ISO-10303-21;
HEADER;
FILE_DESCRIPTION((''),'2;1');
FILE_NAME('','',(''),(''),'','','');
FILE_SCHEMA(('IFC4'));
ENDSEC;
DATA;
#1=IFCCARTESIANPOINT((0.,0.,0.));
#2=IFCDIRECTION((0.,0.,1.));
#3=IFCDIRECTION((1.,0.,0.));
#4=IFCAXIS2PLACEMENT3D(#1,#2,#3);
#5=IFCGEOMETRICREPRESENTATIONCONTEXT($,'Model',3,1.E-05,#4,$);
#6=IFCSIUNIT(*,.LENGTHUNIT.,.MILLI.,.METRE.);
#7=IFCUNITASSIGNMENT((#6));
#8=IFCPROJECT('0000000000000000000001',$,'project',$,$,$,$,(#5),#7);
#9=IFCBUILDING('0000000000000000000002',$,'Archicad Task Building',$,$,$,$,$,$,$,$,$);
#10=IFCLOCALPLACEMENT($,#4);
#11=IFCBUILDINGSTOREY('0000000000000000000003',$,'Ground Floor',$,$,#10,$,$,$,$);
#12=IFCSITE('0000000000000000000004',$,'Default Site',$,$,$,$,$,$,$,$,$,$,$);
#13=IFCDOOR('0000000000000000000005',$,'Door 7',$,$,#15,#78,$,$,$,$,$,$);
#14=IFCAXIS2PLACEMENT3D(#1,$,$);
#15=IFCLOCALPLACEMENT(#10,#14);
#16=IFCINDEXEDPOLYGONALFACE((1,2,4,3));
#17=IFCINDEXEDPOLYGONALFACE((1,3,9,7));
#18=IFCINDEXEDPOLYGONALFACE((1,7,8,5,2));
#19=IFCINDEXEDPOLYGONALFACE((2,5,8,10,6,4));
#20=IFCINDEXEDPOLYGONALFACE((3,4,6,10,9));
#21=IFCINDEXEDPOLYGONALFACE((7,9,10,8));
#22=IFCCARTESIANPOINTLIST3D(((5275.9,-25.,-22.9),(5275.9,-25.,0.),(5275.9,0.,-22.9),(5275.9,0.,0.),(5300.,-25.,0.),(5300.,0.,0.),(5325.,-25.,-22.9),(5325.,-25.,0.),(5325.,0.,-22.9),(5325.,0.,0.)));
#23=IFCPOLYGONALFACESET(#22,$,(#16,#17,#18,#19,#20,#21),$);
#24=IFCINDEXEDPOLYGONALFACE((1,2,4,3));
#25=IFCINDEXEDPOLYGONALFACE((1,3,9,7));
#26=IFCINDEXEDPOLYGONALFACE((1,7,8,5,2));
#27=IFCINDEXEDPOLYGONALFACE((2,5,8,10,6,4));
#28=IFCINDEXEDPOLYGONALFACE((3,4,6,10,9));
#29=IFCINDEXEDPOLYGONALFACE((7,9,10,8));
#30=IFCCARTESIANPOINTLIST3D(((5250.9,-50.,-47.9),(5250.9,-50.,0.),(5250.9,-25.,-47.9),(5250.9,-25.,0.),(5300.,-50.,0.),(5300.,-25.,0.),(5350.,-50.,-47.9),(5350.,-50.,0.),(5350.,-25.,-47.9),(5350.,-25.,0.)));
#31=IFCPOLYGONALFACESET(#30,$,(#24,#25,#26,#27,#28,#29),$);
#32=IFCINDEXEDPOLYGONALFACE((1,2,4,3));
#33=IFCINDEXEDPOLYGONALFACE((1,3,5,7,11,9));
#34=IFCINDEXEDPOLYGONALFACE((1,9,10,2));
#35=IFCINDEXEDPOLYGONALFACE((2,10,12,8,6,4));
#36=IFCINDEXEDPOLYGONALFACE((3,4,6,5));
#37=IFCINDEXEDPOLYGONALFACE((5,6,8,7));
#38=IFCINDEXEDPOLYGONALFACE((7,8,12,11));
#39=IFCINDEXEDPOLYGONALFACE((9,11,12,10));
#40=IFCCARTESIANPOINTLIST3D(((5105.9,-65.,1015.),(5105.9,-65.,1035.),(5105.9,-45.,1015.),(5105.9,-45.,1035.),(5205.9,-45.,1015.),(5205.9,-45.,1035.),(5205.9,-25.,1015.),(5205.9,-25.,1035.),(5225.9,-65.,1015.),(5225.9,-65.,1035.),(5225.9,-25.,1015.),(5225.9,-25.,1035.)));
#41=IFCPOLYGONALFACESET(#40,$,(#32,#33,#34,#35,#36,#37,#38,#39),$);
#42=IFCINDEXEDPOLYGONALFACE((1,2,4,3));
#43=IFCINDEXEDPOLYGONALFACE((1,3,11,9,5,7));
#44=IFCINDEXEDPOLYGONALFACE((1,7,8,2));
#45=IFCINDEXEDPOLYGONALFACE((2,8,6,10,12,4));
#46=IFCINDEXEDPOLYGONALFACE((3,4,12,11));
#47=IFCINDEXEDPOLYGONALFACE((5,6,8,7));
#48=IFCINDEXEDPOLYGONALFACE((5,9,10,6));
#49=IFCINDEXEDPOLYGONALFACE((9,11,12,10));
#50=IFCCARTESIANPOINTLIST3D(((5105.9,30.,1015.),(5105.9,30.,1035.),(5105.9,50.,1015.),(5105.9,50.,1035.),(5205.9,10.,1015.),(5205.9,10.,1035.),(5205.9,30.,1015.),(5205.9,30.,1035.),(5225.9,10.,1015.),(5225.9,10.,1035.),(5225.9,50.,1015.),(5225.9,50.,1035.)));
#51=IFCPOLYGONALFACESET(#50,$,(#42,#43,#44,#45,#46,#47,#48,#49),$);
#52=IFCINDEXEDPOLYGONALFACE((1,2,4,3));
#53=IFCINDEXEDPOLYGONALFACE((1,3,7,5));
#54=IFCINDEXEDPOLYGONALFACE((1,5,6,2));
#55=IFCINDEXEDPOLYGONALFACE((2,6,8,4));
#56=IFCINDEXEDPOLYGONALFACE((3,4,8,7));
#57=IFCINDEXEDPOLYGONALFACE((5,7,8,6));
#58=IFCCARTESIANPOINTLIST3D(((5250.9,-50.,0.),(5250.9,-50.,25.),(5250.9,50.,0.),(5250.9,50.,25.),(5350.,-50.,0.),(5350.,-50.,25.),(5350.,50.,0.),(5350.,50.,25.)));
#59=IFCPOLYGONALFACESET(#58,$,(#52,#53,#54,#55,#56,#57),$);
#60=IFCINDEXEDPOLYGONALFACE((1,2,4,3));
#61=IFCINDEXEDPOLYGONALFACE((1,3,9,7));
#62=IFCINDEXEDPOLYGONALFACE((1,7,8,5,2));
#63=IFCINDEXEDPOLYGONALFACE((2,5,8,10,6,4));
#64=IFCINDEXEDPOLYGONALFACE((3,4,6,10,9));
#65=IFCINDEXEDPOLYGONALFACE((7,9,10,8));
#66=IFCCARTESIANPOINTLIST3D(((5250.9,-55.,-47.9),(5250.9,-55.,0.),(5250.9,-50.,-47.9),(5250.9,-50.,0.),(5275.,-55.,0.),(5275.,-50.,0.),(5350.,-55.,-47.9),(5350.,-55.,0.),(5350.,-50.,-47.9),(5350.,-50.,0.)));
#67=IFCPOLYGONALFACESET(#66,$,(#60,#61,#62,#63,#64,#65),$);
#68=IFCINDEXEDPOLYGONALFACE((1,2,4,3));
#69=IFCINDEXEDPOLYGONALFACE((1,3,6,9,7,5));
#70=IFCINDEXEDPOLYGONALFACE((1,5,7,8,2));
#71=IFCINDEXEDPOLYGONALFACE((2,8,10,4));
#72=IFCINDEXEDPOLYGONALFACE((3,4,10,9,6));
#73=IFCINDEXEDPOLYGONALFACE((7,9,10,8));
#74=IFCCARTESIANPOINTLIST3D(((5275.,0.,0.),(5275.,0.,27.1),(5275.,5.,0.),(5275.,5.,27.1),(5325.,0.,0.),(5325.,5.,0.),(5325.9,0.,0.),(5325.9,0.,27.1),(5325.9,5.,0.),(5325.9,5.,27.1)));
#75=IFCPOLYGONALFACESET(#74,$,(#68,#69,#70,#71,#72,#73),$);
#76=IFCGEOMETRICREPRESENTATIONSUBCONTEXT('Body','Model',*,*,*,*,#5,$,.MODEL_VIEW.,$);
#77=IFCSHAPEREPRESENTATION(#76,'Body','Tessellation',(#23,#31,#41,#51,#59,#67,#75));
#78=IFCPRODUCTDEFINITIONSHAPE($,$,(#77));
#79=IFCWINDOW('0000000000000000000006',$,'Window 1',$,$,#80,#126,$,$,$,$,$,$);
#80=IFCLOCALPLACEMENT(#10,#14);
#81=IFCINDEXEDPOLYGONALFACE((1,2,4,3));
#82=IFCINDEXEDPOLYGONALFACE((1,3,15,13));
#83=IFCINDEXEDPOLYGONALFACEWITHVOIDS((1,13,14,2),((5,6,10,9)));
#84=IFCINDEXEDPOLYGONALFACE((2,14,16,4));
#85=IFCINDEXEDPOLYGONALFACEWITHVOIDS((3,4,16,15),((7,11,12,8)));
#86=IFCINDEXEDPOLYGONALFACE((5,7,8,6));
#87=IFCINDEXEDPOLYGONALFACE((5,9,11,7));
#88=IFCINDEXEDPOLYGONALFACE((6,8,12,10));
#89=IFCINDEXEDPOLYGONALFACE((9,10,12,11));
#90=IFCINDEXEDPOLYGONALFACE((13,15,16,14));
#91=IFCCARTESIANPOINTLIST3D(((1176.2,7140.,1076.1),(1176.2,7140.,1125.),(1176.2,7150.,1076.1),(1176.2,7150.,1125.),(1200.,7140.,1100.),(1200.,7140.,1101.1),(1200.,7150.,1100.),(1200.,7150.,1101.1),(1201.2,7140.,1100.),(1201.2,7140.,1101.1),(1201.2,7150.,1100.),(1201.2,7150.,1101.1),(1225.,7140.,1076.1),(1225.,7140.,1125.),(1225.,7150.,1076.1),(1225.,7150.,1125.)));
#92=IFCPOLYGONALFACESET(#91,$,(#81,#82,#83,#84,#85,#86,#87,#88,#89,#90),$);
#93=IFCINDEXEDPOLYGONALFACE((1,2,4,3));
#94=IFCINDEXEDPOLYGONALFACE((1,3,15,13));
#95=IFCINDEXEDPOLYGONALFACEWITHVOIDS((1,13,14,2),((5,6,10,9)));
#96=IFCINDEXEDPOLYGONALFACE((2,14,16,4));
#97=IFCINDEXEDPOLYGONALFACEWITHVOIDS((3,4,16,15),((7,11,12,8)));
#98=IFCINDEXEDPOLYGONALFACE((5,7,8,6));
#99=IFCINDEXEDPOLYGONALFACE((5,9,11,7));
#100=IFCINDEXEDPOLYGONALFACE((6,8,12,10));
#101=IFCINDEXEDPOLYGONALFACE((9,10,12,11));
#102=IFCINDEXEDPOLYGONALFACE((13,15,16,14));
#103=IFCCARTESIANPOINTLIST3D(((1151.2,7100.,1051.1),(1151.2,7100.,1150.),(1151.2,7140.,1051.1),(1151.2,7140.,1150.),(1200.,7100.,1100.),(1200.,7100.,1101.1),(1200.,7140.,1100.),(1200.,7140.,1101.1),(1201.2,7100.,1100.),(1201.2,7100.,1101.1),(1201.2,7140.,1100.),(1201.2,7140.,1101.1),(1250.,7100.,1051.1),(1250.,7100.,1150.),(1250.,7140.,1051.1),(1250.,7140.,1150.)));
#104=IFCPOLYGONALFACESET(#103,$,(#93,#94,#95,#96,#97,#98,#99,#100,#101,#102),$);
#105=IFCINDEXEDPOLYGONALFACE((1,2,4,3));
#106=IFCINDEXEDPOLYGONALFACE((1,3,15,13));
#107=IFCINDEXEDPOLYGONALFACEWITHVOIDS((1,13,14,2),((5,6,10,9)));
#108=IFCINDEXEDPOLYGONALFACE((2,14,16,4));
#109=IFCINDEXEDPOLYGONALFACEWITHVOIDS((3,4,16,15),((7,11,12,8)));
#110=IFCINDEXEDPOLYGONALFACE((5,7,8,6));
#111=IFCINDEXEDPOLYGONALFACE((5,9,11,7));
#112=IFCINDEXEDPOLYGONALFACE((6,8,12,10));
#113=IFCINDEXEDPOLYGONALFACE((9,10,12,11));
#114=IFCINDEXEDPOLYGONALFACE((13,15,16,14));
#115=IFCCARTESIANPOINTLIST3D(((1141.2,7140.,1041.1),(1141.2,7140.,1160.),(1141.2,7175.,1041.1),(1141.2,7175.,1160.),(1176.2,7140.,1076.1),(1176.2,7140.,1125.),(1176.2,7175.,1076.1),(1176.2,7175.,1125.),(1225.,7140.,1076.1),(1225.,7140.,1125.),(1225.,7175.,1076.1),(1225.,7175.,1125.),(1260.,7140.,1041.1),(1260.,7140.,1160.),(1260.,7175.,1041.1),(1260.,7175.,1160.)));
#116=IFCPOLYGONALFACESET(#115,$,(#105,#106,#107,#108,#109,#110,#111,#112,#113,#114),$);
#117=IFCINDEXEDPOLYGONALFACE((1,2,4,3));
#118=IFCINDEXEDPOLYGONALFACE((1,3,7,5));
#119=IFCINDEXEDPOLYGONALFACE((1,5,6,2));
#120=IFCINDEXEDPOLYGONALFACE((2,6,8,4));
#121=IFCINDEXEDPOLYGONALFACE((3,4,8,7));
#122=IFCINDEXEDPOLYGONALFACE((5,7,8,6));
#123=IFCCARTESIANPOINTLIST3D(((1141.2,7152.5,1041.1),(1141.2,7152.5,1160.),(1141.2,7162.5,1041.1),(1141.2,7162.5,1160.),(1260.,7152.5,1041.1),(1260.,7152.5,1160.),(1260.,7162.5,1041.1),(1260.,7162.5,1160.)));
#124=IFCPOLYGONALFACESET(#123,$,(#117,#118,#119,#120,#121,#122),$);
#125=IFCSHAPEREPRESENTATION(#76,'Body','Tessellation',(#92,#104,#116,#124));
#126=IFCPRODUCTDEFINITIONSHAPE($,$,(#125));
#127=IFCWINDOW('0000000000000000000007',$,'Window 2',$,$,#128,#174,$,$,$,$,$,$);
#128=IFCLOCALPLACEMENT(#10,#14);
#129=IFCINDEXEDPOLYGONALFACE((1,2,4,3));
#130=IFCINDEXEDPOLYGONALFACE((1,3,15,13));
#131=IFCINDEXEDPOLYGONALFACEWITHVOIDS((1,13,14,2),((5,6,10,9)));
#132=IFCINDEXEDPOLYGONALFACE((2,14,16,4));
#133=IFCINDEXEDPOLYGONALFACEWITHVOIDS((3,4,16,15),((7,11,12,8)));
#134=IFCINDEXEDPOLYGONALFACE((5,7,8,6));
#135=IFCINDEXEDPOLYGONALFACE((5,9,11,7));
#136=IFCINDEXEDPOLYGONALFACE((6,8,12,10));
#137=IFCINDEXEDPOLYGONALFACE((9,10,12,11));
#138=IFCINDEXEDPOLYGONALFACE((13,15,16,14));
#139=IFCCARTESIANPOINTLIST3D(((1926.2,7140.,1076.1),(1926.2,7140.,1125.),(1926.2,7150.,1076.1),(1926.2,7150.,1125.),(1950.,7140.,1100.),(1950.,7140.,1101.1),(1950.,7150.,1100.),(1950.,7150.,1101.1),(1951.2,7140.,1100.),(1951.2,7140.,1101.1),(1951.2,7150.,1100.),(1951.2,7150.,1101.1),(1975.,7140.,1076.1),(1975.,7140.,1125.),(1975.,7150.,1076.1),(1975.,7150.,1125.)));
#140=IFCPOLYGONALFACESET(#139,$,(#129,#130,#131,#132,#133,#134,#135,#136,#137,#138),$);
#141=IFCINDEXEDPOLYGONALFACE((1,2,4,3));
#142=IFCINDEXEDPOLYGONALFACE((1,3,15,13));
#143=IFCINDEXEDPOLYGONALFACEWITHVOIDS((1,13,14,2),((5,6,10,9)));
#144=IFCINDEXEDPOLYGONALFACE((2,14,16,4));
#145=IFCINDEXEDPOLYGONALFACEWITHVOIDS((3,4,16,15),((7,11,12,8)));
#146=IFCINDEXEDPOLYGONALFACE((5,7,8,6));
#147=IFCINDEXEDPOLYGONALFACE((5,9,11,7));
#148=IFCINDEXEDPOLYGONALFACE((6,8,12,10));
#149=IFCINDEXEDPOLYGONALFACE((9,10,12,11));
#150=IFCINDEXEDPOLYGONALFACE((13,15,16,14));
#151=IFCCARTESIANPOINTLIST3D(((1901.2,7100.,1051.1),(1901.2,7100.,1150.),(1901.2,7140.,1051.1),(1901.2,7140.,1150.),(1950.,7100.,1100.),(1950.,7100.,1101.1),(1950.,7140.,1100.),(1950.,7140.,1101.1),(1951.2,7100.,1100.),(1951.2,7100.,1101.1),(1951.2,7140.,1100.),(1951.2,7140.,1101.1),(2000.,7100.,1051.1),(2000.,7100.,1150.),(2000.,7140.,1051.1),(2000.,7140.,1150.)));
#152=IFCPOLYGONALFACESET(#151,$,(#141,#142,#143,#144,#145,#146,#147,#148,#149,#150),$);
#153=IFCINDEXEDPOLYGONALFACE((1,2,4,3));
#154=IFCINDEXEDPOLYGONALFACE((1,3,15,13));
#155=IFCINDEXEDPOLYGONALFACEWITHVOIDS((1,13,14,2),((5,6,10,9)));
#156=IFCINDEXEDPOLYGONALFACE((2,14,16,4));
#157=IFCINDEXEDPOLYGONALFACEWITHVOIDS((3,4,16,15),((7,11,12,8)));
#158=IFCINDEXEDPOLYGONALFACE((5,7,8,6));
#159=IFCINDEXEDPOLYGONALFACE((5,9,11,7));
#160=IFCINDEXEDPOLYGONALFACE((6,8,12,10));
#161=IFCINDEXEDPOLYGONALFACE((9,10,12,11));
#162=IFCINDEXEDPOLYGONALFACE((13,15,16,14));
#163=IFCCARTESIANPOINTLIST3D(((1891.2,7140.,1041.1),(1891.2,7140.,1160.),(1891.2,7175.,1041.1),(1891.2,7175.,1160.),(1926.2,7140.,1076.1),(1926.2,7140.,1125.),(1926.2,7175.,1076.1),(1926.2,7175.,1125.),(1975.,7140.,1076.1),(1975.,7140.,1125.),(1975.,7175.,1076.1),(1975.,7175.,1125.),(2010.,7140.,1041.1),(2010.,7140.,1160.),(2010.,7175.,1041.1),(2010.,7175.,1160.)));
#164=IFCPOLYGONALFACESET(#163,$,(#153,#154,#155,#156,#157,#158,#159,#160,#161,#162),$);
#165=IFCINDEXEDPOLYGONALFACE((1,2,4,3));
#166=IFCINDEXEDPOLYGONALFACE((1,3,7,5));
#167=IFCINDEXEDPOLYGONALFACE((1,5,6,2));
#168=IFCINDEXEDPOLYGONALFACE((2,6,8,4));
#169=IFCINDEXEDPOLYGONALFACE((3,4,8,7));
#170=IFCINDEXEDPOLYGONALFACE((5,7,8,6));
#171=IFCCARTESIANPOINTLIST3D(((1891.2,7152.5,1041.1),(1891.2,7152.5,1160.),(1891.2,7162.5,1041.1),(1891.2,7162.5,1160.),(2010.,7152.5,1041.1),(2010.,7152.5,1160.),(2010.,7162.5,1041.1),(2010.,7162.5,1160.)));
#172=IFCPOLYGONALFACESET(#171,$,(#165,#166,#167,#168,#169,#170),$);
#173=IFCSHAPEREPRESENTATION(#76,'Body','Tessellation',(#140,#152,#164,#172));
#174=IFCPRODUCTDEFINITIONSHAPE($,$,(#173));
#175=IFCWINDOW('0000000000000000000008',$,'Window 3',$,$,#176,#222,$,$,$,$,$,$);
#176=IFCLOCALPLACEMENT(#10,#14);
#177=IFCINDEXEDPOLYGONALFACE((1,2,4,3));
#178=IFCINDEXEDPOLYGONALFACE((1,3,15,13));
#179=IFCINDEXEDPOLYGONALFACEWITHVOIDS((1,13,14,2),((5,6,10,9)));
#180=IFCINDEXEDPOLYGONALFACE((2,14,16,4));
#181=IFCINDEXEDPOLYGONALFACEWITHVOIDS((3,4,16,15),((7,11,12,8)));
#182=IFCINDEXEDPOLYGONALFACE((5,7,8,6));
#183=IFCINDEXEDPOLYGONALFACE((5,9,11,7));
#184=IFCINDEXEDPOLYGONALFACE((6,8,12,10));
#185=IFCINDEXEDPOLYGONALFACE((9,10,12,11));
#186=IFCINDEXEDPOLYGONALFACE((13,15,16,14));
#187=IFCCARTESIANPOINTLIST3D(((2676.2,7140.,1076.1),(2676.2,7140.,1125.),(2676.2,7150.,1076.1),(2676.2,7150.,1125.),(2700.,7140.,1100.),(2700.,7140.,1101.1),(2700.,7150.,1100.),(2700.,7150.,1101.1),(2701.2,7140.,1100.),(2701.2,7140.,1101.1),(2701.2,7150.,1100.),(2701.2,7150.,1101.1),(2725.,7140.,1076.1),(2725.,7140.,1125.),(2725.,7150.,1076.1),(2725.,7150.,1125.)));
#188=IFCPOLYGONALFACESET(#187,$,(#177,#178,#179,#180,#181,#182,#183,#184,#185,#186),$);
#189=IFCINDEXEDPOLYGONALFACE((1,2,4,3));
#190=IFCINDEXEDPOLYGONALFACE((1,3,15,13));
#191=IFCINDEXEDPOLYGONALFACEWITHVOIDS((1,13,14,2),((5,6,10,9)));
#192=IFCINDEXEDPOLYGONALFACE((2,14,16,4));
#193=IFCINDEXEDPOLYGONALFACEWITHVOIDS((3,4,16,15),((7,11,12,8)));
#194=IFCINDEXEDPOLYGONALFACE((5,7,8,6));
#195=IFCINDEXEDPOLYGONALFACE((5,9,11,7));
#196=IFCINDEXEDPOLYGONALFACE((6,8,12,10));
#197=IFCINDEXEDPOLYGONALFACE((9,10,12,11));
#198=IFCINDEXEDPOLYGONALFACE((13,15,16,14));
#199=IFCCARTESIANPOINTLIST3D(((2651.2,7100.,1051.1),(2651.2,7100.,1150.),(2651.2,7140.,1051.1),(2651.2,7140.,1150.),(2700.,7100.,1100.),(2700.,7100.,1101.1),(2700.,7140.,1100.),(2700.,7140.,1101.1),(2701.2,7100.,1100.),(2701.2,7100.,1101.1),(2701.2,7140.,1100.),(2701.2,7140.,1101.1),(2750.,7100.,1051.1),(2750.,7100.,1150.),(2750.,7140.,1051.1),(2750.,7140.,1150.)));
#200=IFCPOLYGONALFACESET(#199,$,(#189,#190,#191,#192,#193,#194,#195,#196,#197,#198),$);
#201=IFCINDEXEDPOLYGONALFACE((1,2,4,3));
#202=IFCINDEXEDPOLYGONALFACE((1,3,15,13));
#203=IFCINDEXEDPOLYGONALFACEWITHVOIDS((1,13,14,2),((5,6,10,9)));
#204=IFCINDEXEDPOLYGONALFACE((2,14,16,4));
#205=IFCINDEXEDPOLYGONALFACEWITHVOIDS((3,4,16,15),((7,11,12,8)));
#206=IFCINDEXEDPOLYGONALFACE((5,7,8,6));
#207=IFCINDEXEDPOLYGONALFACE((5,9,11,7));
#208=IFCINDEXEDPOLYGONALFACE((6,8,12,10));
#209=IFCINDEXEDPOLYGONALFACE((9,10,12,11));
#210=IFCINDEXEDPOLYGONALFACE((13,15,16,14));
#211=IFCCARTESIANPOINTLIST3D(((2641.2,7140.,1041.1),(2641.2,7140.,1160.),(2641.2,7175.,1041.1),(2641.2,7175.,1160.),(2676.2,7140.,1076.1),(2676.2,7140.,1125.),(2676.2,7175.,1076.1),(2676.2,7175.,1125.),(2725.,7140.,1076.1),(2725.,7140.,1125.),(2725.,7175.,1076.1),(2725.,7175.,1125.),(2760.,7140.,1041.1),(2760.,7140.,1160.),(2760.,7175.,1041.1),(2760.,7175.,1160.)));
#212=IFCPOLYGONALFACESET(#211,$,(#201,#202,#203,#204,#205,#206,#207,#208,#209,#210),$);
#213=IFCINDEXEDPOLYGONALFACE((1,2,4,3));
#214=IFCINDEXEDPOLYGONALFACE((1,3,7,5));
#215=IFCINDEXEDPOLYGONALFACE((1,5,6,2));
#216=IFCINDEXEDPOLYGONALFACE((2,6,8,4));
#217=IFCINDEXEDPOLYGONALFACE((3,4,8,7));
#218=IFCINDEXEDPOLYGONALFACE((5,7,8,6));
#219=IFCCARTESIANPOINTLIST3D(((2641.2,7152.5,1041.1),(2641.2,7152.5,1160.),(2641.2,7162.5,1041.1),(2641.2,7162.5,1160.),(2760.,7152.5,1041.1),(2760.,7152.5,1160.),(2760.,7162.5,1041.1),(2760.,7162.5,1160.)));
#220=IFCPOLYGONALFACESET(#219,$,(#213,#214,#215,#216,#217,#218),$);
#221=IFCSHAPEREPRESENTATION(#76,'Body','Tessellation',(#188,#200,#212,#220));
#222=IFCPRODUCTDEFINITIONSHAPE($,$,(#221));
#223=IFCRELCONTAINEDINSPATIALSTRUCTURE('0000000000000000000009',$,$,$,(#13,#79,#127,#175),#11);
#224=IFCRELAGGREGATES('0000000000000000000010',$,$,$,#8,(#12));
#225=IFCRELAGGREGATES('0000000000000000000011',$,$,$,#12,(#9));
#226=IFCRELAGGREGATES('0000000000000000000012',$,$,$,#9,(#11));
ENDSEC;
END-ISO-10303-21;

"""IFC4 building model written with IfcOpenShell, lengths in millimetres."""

from ifc_helpers import new_model, si_unit, frame, origin_with_axes, place, context, subcontext, project, spatial, line, indexed_curve, outline, extrude, element, save


model = new_model("IFC4")

# Units and contexts
model_context = context("Model", 3, precision=1e-05, world=origin_with_axes())
body_context = subcontext(model_context, "Body", "Model", "MODEL_VIEW")
ifc_project = project(units=[si_unit("LENGTHUNIT", "METRE", prefix="MILLI")], contexts=[model_context])

# Site, building, storey
site = spatial("IfcSite", under=ifc_project, Name="Default Site")
building = spatial("IfcBuilding", under=site, Name="Archicad Task Building")
storey_placement = place(None, origin_with_axes())
storey = spatial("IfcBuildingStorey", under=building, at=storey_placement, Name="Ground Floor")

# Door
door_1_placement = place(storey_placement, frame((5300.0, -50.0, 0.0), z_axis=(0.0, 0.0, 1.0), x_axis=(1.0, 0.0, 0.0)))
element("IfcDoor", 1, at=door_1_placement, inside=storey, Name="Door 7", context=body_context, shape_type="SweptSolid", body=[
    extrude(outline(indexed_curve([(0.0, 0.0), (0.0, 2.1), (0.9, 2.1), (0.9, 0.0), (-24.1, 0.0), (-24.1, -22.9), (25.0, -22.9), (25.0, 0.0)], segments=[line(1, 2, 3, 4, 5, 6, 7, 8, 1)])), frame((0.0, 25.0, 0.0), z_axis=(0.0, -1.0, 0.0), x_axis=(1.0, 0.0, 0.0)), (0.0, 0.0, -1.0), 25.0),
    extrude(outline(indexed_curve([(0.0, 0.0), (0.0, 2.1), (0.9, 2.1), (0.9, 0.0), (-49.1, 0.0), (-49.1, -47.9), (50.0, -47.9), (50.0, 0.0)], segments=[line(1, 2, 3, 4, 5, 6, 7, 8, 1)])), frame((0.0, 0.0, 0.0), z_axis=(0.0, -1.0, 0.0), x_axis=(1.0, 0.0, 0.0)), (0.0, 0.0, -1.0), 25.0),
    extrude(outline(indexed_curve([(0.0, 0.0), (-49.1, 0.0), (-49.1, 35.0), (0.0, 35.0)], segments=[line(1, 2, 3, 4, 1)])), frame((25.0, 25.0, 25.0), z_axis=(0.0, 0.0, 1.0), x_axis=(1.0, 0.0, 0.0)), (0.0, 0.0, 1.0), -47.9),
    extrude(outline(indexed_curve([(0.0, 0.0), (0.0, -40.0), (-120.0, -40.0), (-120.0, -20.0), (-20.0, -20.0), (-20.0, 0.0)], segments=[line(1, 2, 3, 4, 5, 6, 1)])), frame((-74.1, 25.0, 1015.0), z_axis=(0.0, 0.0, 1.0), x_axis=(1.0, 0.0, 0.0)), (0.0, 0.0, 1.0), 20.0),
    extrude(outline(indexed_curve([(0.0, 0.0), (0.0, 40.0), (-120.0, 40.0), (-120.0, 20.0), (-20.0, 20.0), (-20.0, 0.0)], segments=[line(1, 2, 3, 4, 5, 6, 1)])), frame((-74.1, 60.0, 1015.0), z_axis=(0.0, 0.0, 1.0), x_axis=(1.0, 0.0, 0.0)), (0.0, 0.0, 1.0), 20.0),
    extrude(outline(indexed_curve([(0.0, 0.0), (-99.1, 0.0), (-99.1, 100.0), (0.0, 100.0)], segments=[line(1, 2, 3, 4, 1)])), frame((50.0, 0.0, 0.0), z_axis=(0.0, 0.0, 1.0), x_axis=(1.0, 0.0, 0.0)), (0.0, 0.0, 1.0), 25.0),
    extrude(outline(indexed_curve([(0.0, 0.0), (0.0, 27.1), (50.9, 27.1), (50.9, 0.0), (-24.1, 0.0), (-24.1, -47.9), (75.0, -47.9), (75.0, 0.0)], segments=[line(1, 2, 3, 4, 5, 6, 7, 8, 1)])), frame((-25.0, -5.0, 0.0), z_axis=(0.0, -1.0, 0.0), x_axis=(1.0, 0.0, 0.0)), (0.0, 0.0, -1.0), 5.0),
    extrude(outline(indexed_curve([(0.0, 0.0), (0.0, 27.1), (50.9, 27.1), (50.9, 0.0), (0.9, 0.0), (0.9, -22.9), (50.0, -22.9), (50.0, 0.0)], segments=[line(1, 2, 3, 4, 5, 6, 7, 8, 1)])), frame((-25.0, 50.0, 0.0), z_axis=(0.0, -1.0, 0.0), x_axis=(1.0, 0.0, 0.0)), (0.0, 0.0, -1.0), 5.0),
])

# Windows
for number, where, z_axis, x_axis, name in (
    (2, (1200.0, 7050.0, 1100.0), (0.0, 0.0, 1.0), (1.0, 0.0, 0.0), "Window 1"),
    (3, (1950.0, 7050.0, 1100.0), (0.0, 0.0, 1.0), (1.0, 0.0, 0.0), "Window 2"),
    (4, (2700.0, 7050.0, 1100.0), (0.0, 0.0, 1.0), (1.0, 0.0, 0.0), "Window 3"),
):
    element("IfcWindow", number, at=place(storey_placement, frame(where, z_axis=z_axis, x_axis=x_axis)), inside=storey, Name=name, context=body_context, shape_type="SweptSolid", body=[
        extrude(outline(indexed_curve([(0.0, 0.0), (1.2, 0.0), (1.2, 1.1), (0.0, 1.1)], segments=[line(1, 2, 3, 4, 1)]), holes=[indexed_curve([(25.0, 25.0), (-23.8, 25.0), (-23.8, -23.9), (25.0, -23.9)], segments=[line(1, 2, 3, 4, 1)])]), frame((0.0, 90.0, 0.0), z_axis=(0.0, -1.0, 0.0), x_axis=(1.0, 0.0, 0.0)), (0.0, 0.0, -1.0), 10.0),
        extrude(outline(indexed_curve([(0.0, 0.0), (1.2, 0.0), (1.2, 1.1), (0.0, 1.1)], segments=[line(1, 2, 3, 4, 1)]), holes=[indexed_curve([(50.0, 50.0), (-48.8, 50.0), (-48.8, -48.9), (50.0, -48.9)], segments=[line(1, 2, 3, 4, 1)])]), frame((0.0, 50.0, 0.0), z_axis=(0.0, -1.0, 0.0), x_axis=(1.0, 0.0, 0.0)), (0.0, 0.0, -1.0), 40.0),
        extrude(outline(indexed_curve([(0.0, 0.0), (-48.8, 0.0), (-48.8, -48.9), (0.0, -48.9)], segments=[line(1, 2, 3, 4, 1)]), holes=[indexed_curve([(35.0, 35.0), (-83.8, 35.0), (-83.8, -83.9), (35.0, -83.9)], segments=[line(1, 2, 3, 4, 1)])]), frame((25.0, 90.0, 25.0), z_axis=(0.0, -1.0, 0.0), x_axis=(1.0, 0.0, 0.0)), (0.0, 0.0, -1.0), 35.0),
        extrude(outline(indexed_curve([(35.0, 35.0), (-83.8, 35.0), (-83.8, -83.9), (35.0, -83.9)], segments=[line(1, 2, 3, 4, 1)])), frame((25.0, 102.5, 25.0), z_axis=(0.0, -1.0, 0.0), x_axis=(1.0, 0.0, 0.0)), (0.0, 0.0, -1.0), 10.0),
    ])

save(model, "model.ifc")
